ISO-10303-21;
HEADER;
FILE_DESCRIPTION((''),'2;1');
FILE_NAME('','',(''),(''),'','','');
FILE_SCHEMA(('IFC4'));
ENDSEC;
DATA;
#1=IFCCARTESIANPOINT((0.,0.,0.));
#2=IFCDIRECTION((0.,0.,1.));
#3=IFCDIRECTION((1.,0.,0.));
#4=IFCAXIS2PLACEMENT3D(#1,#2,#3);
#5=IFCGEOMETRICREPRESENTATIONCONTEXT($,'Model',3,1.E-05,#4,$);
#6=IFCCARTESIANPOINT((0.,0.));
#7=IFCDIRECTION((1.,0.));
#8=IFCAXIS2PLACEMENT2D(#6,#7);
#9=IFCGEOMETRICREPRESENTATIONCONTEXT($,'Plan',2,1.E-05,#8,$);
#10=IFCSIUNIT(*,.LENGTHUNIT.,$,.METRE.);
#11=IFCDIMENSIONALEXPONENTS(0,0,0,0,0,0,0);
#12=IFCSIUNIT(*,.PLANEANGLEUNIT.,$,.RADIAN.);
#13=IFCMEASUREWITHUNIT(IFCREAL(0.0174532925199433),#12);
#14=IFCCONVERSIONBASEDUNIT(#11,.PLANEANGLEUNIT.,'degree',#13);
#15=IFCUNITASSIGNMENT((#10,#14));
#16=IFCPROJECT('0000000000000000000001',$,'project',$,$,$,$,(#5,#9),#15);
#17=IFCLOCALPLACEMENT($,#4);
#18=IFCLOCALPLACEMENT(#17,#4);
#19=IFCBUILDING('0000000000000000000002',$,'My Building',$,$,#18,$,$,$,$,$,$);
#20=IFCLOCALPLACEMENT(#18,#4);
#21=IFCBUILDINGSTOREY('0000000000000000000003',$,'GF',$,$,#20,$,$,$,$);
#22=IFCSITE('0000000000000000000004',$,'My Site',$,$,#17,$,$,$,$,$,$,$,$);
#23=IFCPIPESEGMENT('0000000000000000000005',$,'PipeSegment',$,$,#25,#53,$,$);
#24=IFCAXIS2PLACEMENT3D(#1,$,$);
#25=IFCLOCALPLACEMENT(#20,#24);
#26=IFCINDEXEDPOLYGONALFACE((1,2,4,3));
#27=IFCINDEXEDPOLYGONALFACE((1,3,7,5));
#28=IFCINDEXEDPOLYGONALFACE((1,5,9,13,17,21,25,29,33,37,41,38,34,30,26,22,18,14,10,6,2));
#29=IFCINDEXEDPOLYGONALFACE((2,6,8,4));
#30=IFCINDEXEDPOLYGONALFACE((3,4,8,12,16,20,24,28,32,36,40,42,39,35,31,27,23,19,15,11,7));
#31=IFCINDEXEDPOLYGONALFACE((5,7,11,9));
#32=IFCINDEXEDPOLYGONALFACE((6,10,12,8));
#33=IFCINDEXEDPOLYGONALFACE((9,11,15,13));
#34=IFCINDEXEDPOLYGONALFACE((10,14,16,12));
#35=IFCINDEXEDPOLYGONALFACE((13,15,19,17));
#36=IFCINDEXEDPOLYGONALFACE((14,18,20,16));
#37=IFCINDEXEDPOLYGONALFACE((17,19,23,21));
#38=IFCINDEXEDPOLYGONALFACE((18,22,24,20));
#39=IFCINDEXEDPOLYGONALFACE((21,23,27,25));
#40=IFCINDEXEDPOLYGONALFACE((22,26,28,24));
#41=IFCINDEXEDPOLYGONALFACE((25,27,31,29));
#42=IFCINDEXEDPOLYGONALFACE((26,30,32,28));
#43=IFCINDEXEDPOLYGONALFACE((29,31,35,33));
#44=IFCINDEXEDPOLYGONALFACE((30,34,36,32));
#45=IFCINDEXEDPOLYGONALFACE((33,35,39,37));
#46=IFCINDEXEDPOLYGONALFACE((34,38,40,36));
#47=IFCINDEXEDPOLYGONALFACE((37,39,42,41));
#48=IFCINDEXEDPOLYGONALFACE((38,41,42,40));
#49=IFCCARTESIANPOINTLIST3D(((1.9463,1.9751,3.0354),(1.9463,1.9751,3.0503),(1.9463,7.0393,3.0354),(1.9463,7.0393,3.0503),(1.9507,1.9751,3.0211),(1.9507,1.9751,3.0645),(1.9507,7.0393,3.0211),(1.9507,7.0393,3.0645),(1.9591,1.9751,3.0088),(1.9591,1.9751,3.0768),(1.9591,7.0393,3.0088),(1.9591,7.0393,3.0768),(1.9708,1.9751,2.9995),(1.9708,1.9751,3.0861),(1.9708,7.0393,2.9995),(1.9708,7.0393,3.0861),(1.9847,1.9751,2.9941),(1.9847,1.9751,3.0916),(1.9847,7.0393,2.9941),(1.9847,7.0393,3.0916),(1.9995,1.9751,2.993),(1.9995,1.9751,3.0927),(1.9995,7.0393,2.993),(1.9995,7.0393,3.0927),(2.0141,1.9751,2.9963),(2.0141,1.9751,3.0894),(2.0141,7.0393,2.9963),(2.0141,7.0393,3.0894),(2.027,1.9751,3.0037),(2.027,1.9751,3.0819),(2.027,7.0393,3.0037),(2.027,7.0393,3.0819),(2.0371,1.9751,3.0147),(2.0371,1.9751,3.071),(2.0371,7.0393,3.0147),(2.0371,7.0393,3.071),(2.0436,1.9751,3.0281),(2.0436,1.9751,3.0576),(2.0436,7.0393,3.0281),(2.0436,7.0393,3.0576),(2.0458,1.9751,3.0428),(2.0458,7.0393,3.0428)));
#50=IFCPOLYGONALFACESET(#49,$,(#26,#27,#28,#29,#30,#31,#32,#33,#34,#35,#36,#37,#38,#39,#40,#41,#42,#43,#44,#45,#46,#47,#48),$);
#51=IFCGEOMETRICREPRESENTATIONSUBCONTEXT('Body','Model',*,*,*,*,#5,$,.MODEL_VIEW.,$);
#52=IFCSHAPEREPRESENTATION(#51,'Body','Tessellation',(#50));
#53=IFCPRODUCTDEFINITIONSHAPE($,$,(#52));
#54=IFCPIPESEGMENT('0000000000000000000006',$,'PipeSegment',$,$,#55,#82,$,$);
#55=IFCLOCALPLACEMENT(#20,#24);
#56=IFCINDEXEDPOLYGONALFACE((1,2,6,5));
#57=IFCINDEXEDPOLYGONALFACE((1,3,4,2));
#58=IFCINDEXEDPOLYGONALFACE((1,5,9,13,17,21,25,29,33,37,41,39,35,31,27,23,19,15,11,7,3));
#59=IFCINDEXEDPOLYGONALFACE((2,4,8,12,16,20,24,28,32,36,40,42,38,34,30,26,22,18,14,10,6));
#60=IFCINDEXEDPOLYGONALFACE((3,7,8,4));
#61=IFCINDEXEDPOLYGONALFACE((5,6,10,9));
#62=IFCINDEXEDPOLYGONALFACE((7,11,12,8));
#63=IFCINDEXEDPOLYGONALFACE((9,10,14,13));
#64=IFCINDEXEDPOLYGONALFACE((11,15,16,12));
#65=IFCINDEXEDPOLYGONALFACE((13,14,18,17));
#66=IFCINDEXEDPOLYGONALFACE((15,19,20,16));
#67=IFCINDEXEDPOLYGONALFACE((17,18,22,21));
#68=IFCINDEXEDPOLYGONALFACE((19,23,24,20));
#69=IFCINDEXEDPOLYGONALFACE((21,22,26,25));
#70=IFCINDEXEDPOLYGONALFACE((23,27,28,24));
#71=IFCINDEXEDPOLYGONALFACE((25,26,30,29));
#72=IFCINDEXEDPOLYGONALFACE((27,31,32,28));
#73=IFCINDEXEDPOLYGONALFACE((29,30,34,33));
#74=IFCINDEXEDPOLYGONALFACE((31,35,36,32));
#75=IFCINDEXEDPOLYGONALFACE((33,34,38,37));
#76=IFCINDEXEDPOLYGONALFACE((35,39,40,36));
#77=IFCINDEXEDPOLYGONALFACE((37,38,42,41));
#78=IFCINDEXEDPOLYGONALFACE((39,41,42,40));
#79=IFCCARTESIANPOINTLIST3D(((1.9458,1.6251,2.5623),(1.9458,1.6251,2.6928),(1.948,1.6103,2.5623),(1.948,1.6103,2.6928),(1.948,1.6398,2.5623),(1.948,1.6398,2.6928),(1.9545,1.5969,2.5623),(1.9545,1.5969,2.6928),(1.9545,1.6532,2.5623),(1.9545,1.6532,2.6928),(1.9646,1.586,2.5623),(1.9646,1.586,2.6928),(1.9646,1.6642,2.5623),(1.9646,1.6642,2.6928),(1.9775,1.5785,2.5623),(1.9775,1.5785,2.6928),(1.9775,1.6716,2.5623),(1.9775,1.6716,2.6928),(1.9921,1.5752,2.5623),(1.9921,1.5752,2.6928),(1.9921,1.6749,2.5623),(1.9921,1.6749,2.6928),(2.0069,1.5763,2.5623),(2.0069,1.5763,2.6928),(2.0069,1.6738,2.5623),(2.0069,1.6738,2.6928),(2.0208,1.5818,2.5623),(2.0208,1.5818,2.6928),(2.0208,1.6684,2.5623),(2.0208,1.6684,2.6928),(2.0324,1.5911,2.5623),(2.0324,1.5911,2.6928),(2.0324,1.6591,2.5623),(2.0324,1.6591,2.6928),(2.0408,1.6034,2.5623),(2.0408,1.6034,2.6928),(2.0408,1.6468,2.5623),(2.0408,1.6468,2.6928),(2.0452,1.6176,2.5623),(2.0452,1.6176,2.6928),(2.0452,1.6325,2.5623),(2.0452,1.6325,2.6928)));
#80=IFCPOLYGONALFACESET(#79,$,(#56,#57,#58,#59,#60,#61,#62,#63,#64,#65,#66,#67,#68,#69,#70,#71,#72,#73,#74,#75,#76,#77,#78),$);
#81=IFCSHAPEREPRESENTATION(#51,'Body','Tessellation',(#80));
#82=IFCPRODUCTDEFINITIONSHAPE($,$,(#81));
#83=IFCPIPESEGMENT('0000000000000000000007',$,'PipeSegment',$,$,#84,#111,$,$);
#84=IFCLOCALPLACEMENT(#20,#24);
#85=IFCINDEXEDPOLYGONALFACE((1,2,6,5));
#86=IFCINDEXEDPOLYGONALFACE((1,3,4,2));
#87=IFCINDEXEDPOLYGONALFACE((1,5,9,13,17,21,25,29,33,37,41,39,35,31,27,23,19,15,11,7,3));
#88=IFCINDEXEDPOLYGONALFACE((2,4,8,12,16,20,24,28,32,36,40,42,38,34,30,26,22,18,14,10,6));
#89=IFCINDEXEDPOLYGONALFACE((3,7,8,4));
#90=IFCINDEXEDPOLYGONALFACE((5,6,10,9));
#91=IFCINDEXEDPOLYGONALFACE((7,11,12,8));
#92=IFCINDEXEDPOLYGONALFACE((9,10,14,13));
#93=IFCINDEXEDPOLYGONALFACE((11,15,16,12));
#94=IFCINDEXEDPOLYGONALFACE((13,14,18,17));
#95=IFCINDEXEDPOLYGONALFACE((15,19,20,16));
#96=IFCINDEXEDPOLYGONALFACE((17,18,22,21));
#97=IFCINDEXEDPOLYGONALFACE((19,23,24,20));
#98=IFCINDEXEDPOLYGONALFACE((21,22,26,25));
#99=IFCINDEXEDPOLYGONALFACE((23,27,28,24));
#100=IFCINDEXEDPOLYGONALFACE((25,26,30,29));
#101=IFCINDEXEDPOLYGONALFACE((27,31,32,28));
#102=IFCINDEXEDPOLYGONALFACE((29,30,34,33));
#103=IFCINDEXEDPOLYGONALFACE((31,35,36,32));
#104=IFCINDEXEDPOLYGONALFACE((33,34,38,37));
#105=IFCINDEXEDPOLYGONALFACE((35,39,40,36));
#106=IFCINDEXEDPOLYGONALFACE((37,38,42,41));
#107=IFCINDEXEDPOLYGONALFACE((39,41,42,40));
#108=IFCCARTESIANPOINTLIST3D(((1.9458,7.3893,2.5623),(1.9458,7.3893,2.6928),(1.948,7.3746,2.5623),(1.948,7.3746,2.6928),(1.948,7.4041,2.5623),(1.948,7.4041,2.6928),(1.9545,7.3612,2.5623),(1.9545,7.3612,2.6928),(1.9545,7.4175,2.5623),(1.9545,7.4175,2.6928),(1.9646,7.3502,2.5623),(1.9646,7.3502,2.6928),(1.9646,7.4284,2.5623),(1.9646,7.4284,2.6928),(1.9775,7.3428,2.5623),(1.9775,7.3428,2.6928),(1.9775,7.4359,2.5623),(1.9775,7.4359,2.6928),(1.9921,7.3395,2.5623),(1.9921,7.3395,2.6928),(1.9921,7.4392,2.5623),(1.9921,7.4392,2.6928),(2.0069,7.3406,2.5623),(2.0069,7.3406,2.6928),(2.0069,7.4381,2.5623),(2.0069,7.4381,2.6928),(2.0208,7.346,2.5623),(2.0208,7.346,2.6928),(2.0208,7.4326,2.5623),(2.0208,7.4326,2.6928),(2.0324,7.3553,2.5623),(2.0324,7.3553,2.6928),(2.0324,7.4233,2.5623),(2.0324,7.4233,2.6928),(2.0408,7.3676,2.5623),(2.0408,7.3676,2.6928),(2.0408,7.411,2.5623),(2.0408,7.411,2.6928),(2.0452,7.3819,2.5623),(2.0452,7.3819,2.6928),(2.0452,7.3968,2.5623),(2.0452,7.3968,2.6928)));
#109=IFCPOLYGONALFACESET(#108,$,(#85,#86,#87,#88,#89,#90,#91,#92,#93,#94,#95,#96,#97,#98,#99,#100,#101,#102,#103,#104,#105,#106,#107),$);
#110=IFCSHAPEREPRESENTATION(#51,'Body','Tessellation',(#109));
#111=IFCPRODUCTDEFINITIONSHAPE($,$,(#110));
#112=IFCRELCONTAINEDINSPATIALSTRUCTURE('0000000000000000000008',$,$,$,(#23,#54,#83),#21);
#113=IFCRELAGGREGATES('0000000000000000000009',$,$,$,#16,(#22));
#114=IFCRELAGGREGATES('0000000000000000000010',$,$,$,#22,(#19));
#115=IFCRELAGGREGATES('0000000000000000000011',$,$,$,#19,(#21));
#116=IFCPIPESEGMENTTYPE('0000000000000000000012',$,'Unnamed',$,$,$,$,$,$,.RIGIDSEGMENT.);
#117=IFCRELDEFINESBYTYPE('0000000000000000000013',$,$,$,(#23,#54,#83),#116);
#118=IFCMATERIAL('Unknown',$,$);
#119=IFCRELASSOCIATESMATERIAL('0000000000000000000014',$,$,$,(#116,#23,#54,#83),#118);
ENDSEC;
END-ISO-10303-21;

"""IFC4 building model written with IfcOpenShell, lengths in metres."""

from ifc_helpers import new_model, entity, si_unit, converted_unit, frame, origin_with_axes, origin_2d_with_axis, place, context, subcontext, project, spatial, circle, extrude, material, material_profile, profile_set, profile_usage, type_object, element, save


model = new_model("IFC4")

# Units and contexts
model_context = context("Model", 3, precision=1e-05, world=origin_with_axes())
plan_context = context("Plan", 2, precision=1e-05, world=origin_2d_with_axis())
body_context_1 = subcontext(model_context, "Body", "Model", "MODEL_VIEW")
ifc_project = project(units=[si_unit("LENGTHUNIT", "METRE"), converted_unit("PLANEANGLEUNIT", "degree", entity("IfcReal", 0.0174532925199433), si_unit("PLANEANGLEUNIT", "RADIAN"), dimensions=[0, 0, 0, 0, 0, 0, 0])], contexts=[model_context, plan_context])

# Site, building, storey
site_placement = place(None, origin_with_axes())
site = spatial("IfcSite", under=ifc_project, at=site_placement, Name="My Site")
building_placement = place(site_placement, origin_with_axes())
building = spatial("IfcBuilding", under=site, at=building_placement, Name="My Building")
storey_placement = place(building_placement, origin_with_axes())
storey = spatial("IfcBuildingStorey", under=building, at=storey_placement, Name="GF")

# Shared definitions
ifc_material = material(Name="Unknown")

# Pipe segments
ifc_material_profile = material_profile(ifc_material, circle(Radius=0.05))
ifc_profile_set = profile_set([ifc_material_profile])
pipe_segment_type = type_object("IfcPipeSegmentType", Name="Unnamed", PredefinedType="RIGIDSEGMENT", material=ifc_profile_set)
ifc_profile_usage_1 = profile_usage(ifc_profile_set, cardinal=5)
pipe_segment_1_placement = place(storey_placement, frame((1.9958, 7.0393, 3.0428), z_axis=(0.0, -1.0, 0.0), x_axis=(1.0, 0.0, 0.0)))
element("IfcPipeSegment", 1, at=pipe_segment_1_placement, inside=storey, type_object=pipe_segment_type, material=ifc_profile_usage_1, Name="PipeSegment", context=body_context_1, shape_type="SweptSolid", body=[
    extrude(circle(Radius=0.05), origin_with_axes(), (0.0, 0.0, 1.0), 5.0643),
])
ifc_profile_usage_2 = profile_usage(ifc_profile_set, cardinal=5)
pipe_segment_2_placement = place(storey_placement, frame((1.9958, 1.6251, 2.6928), z_axis=(0.0, 0.0, -1.0), x_axis=(-1.0, 0.0, 0.0)))
element("IfcPipeSegment", 2, at=pipe_segment_2_placement, inside=storey, type_object=pipe_segment_type, material=ifc_profile_usage_2, Name="PipeSegment", context=body_context_1, shape_type="SweptSolid", body=[
    extrude(circle(Radius=0.05), origin_with_axes(), (0.0, 0.0, 1.0), 0.1306),
])
ifc_profile_usage_3 = profile_usage(ifc_profile_set, cardinal=5)
pipe_segment_3_placement = place(storey_placement, frame((1.9958, 7.3893, 2.6928), z_axis=(0.0, 0.0, -1.0), x_axis=(-1.0, 0.0, 0.0)))
element("IfcPipeSegment", 3, at=pipe_segment_3_placement, inside=storey, type_object=pipe_segment_type, material=ifc_profile_usage_3, Name="PipeSegment", context=body_context_1, shape_type="SweptSolid", body=[
    extrude(circle(Radius=0.05), origin_with_axes(), (0.0, 0.0, 1.0), 0.1306),
])

save(model, "model.ifc")
